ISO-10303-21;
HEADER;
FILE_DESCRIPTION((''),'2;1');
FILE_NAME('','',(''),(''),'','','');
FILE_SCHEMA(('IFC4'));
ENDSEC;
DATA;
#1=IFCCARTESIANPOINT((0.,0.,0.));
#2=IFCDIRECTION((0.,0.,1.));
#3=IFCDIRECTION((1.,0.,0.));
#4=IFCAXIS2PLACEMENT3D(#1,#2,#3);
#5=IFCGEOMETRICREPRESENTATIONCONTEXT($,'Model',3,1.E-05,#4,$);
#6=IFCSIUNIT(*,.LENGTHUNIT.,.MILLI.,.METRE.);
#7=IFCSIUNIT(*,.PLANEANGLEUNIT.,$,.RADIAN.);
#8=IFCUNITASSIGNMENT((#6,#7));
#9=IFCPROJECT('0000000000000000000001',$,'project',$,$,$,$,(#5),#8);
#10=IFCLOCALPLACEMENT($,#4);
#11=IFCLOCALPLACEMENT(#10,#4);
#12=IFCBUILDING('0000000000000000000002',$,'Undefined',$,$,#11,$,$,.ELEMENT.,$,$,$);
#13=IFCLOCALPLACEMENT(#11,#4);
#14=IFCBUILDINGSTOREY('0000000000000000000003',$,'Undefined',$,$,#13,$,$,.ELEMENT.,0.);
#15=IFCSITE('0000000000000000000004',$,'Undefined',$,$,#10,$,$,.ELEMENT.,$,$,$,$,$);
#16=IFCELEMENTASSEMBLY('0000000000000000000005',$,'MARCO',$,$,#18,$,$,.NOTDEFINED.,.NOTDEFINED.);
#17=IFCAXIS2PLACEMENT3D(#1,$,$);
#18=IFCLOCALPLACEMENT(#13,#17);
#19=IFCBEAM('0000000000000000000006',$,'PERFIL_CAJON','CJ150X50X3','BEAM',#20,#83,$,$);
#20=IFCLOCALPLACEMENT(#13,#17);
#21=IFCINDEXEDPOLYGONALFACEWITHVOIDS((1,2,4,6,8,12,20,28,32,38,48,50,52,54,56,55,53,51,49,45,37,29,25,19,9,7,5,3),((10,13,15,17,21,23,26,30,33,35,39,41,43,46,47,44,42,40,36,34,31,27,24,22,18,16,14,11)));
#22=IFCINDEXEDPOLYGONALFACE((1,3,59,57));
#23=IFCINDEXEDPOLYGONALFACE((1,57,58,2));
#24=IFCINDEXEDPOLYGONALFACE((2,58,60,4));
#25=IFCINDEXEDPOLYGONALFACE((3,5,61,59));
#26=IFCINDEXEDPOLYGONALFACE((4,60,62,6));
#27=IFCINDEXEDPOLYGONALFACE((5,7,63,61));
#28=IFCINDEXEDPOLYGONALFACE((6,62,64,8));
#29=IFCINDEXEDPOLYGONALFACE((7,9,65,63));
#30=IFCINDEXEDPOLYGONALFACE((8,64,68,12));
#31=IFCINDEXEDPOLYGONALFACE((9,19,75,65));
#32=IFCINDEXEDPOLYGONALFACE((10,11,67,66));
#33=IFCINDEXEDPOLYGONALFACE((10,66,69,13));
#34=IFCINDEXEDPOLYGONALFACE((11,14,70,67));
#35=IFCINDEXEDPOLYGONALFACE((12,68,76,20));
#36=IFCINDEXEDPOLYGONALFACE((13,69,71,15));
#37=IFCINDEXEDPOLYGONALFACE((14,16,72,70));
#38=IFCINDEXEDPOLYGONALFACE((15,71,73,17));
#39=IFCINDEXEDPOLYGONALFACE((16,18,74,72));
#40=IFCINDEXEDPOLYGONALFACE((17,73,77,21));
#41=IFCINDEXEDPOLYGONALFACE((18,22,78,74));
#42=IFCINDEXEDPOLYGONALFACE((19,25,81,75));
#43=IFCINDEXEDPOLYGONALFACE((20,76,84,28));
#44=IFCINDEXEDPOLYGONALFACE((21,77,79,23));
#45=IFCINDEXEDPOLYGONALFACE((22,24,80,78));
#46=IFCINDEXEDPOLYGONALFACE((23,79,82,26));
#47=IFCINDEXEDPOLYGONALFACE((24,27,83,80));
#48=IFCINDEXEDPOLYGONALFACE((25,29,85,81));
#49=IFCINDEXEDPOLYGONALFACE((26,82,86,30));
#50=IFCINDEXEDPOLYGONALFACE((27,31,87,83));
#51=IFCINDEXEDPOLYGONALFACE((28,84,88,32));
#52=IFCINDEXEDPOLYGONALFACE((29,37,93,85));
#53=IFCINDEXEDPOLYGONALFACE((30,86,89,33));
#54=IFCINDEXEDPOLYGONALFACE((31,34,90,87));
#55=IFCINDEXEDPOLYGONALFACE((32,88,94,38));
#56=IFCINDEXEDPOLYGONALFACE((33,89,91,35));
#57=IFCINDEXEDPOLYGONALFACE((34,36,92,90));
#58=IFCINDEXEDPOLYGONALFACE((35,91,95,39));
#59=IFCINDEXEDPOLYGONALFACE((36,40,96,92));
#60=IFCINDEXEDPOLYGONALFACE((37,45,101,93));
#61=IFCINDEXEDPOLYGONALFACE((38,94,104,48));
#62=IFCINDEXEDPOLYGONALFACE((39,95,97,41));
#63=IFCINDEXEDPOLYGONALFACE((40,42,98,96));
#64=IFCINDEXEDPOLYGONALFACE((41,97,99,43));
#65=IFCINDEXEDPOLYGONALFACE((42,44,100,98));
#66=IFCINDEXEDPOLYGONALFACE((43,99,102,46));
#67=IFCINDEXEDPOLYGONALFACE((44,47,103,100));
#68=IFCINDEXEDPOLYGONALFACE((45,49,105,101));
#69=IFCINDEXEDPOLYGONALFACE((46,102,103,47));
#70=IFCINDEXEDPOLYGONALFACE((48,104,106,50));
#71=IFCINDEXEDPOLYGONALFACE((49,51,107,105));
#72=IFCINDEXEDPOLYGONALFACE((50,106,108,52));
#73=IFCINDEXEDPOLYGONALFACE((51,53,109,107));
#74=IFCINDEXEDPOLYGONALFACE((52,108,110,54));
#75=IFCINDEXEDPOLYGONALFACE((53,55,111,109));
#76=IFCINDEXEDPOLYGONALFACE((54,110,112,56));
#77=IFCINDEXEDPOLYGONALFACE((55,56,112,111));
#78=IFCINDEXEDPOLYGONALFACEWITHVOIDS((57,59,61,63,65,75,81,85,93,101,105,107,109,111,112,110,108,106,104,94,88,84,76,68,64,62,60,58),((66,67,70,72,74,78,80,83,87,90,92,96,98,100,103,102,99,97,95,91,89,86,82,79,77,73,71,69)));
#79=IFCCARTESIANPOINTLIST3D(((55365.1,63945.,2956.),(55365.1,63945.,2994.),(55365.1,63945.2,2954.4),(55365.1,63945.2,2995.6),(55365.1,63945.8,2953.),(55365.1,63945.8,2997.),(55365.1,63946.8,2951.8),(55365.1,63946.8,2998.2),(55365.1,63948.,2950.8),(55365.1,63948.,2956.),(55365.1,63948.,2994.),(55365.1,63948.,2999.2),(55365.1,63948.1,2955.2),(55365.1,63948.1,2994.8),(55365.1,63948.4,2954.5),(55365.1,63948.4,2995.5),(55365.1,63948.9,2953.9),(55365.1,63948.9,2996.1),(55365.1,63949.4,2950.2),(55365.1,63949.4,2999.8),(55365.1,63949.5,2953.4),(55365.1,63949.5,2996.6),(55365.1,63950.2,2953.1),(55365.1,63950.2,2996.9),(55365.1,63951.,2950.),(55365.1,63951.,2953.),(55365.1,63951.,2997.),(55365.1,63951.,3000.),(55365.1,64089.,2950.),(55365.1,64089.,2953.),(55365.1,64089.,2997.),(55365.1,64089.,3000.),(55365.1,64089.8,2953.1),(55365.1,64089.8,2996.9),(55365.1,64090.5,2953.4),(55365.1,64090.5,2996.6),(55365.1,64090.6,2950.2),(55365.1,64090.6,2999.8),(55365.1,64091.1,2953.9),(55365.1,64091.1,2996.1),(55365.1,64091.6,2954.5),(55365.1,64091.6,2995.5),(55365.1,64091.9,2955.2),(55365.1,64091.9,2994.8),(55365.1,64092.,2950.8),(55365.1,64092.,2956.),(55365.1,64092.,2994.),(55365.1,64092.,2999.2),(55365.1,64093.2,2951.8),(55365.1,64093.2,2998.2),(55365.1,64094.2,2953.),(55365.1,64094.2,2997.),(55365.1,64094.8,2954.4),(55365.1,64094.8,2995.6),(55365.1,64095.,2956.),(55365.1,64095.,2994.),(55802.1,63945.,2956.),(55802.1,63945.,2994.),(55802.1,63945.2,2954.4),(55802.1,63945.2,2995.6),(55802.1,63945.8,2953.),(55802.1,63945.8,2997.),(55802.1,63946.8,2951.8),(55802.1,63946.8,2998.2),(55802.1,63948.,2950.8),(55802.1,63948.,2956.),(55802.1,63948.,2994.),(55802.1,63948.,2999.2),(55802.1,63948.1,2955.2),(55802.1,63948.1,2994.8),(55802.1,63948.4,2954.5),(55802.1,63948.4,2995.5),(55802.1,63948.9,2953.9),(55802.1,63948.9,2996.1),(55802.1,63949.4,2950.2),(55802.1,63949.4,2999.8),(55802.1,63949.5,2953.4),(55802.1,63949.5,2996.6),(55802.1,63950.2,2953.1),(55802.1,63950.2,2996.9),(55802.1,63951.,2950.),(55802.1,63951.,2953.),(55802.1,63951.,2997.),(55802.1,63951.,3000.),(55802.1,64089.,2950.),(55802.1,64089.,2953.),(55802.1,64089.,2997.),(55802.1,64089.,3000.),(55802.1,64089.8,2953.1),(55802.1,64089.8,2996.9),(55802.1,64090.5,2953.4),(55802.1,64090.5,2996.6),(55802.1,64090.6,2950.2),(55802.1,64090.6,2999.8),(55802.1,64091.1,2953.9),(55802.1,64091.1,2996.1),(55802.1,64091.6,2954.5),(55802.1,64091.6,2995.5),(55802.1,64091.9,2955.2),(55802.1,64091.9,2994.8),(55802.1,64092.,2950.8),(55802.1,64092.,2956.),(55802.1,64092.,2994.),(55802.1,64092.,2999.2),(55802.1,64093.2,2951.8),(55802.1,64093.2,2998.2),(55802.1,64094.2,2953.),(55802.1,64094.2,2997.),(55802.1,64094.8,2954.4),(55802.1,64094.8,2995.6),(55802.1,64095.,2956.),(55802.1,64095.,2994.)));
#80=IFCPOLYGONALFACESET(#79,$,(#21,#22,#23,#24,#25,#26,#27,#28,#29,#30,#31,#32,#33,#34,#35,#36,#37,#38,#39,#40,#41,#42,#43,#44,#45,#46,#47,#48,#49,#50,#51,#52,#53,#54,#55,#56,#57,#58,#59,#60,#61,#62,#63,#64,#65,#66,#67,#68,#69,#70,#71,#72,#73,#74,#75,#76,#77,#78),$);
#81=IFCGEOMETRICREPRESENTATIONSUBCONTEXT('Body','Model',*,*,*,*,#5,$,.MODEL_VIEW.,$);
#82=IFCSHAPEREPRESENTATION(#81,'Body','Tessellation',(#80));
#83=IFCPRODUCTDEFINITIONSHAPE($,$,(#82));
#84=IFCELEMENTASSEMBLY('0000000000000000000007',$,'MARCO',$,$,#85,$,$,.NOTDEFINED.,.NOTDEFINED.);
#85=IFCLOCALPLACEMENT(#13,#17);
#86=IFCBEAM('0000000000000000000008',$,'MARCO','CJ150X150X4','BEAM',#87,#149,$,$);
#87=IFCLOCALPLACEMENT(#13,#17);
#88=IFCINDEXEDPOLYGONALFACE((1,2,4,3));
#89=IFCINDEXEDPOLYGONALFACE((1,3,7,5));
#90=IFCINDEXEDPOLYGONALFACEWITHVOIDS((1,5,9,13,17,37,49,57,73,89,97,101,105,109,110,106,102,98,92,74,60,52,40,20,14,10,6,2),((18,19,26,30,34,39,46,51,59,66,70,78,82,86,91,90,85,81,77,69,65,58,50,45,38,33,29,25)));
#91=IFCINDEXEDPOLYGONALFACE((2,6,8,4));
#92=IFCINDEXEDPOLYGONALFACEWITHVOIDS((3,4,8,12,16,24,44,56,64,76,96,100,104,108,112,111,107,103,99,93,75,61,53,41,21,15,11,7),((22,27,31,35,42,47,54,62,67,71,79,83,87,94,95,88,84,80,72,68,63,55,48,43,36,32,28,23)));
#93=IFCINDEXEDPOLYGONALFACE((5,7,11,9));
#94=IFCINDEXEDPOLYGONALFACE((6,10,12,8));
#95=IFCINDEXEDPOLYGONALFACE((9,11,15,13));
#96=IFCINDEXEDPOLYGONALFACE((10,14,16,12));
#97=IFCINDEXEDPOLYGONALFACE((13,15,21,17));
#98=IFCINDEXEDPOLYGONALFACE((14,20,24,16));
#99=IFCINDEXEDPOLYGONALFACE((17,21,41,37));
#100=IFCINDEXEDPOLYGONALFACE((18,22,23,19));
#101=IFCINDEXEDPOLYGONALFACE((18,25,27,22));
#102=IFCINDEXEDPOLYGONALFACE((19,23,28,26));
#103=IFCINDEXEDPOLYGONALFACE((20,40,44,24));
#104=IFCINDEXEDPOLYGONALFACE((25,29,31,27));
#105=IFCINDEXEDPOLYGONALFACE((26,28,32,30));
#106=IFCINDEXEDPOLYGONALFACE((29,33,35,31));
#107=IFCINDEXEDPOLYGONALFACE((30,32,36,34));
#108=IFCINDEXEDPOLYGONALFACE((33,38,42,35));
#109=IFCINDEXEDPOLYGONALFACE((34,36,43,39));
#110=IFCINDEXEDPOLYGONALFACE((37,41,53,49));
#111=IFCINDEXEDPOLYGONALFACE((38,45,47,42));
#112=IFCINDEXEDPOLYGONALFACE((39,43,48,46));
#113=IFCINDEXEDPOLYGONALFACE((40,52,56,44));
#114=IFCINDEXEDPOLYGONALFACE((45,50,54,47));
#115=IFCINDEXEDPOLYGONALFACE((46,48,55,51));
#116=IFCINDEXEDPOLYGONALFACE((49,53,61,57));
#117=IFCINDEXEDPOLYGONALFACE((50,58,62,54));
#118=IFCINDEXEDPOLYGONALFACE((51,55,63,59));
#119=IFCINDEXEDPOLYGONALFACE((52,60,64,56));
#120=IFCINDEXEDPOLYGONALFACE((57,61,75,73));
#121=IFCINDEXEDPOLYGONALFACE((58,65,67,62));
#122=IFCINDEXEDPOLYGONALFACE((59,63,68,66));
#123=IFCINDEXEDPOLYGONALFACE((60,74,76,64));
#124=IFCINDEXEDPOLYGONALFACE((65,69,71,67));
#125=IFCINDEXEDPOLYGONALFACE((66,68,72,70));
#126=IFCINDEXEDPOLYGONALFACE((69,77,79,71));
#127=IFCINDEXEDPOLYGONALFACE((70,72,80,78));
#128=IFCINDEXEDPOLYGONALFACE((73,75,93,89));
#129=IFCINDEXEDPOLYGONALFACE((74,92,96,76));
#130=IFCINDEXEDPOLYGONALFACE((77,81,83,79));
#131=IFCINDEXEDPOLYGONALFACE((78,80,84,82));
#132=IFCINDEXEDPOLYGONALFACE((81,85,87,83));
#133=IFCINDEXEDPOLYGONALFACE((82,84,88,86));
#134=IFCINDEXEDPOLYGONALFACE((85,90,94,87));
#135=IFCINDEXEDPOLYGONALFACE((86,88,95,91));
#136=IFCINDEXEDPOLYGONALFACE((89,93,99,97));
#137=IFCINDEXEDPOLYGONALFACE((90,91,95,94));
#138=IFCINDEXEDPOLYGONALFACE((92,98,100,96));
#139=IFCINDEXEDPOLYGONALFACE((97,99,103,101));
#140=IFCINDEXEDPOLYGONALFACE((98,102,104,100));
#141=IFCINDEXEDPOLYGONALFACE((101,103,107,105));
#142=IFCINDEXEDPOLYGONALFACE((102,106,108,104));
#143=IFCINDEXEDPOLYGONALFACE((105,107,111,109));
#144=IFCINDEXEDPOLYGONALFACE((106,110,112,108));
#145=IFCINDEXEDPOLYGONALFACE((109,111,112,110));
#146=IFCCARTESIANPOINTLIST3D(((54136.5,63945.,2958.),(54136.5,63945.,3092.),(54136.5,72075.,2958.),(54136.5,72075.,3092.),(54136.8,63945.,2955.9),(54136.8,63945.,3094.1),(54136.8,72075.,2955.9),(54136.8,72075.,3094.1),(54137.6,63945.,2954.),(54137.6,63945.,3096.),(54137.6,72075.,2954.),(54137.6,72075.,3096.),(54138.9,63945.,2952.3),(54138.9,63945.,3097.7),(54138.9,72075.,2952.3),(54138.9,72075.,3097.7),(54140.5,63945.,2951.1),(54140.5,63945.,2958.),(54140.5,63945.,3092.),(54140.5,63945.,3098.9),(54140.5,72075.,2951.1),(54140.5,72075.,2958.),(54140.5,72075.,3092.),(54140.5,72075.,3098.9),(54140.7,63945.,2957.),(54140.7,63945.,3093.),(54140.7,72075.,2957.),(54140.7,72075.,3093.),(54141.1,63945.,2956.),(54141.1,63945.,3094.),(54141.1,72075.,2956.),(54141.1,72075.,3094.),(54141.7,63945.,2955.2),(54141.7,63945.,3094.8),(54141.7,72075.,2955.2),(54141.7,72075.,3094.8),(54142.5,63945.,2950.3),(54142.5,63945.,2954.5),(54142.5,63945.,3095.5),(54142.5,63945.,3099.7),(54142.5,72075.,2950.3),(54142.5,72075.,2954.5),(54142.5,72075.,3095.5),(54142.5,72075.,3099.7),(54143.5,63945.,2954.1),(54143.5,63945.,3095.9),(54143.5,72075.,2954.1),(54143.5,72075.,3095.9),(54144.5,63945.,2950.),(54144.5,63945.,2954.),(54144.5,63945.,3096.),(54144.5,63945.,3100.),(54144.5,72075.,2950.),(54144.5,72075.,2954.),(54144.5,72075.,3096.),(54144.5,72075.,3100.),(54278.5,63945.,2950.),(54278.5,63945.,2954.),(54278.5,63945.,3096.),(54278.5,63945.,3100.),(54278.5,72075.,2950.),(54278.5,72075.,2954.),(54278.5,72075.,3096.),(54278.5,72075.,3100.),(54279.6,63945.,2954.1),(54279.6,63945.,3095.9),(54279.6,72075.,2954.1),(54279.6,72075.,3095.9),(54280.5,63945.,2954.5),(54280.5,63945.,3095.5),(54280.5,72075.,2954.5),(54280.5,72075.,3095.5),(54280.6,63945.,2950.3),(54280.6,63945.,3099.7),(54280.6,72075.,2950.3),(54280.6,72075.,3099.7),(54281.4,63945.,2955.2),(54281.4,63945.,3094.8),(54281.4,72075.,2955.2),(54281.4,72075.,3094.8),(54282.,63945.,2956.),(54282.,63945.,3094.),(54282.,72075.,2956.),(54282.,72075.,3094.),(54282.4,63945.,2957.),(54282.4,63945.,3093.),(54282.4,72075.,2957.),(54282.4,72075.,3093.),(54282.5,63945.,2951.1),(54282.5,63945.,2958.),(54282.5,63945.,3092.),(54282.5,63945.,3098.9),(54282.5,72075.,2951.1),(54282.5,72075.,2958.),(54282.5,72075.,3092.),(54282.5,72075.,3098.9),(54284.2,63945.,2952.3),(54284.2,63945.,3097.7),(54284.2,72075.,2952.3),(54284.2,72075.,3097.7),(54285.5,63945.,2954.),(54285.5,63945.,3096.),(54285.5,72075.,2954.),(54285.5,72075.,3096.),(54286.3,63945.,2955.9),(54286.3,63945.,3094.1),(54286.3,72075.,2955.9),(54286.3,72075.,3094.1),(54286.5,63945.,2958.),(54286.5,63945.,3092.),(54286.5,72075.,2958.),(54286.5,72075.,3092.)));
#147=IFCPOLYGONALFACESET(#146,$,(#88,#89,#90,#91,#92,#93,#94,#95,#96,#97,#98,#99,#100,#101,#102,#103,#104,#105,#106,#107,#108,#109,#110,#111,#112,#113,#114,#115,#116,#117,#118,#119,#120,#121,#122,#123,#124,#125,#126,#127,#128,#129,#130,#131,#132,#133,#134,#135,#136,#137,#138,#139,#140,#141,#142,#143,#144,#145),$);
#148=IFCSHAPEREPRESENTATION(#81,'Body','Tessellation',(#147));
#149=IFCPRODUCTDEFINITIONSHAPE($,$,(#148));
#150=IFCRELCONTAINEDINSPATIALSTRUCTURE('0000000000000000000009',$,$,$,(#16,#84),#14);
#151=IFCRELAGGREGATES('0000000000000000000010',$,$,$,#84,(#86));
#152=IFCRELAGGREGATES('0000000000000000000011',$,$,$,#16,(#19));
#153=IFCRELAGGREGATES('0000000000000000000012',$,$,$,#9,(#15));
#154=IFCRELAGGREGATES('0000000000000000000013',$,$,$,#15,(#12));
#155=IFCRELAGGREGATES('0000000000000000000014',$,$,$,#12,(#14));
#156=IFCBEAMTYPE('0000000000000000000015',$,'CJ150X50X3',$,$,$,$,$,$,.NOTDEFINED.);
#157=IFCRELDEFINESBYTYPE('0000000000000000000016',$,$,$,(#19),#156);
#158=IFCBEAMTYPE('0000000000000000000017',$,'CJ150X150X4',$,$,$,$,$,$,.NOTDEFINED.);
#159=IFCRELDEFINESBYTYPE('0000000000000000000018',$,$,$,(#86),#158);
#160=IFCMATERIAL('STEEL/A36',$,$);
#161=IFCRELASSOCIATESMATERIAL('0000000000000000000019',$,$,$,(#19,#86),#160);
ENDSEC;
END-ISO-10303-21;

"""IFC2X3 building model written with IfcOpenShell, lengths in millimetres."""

from ifc_helpers import new_model, si_unit, frame, origin_with_axes, origin_2d_with_axis, place, context, subcontext, project, spatial, hollow_rectangle, extrude, material, type_object, element, aggregate, save


model = new_model("IFC2X3")

# Units and contexts
model_context = context("Model", 3, precision=1e-05, world=origin_with_axes())
body_context = subcontext(model_context, "Body", "Model", "MODEL_VIEW")
ifc_project = project(units=[si_unit("LENGTHUNIT", "METRE", prefix="MILLI"), si_unit("PLANEANGLEUNIT", "RADIAN")], contexts=[model_context])

# Site, building, storey
site_placement = place(None, origin_with_axes())
site = spatial("IfcSite", under=ifc_project, at=site_placement, Name="Undefined", CompositionType="ELEMENT")
building_placement = place(site_placement, origin_with_axes())
building = spatial("IfcBuilding", under=site, at=building_placement, Name="Undefined", CompositionType="ELEMENT")
storey_placement = place(building_placement, origin_with_axes())
storey = spatial("IfcBuildingStorey", under=building, at=storey_placement, Name="Undefined", CompositionType="ELEMENT", Elevation=0.0)

# Element assemblies, beams
assembly_1_placement = place(storey_placement, origin_with_axes())
assembly_1 = element("IfcElementAssembly", 1, at=assembly_1_placement, inside=storey, Name="MARCO", AssemblyPlace="NOTDEFINED", PredefinedType="NOTDEFINED")
ifc_material_1 = material(Name="STEEL/A36")
beam_type_1 = type_object("IfcBeamType", Name="CJ150X50X3", PredefinedType="NOTDEFINED")
beam_1_placement = place(assembly_1_placement, frame((55365.1, 64020.0, 2975.0), z_axis=(0.0, 1.0, 0.0), x_axis=(1.0, 0.0, 0.0)))
beam_1 = element("IfcBeam", 2, at=beam_1_placement, type_object=beam_type_1, material=ifc_material_1, Name="PERFIL_CAJON", Description="CJ150X50X3", ObjectType="BEAM", context=body_context, shape_type="SweptSolid", body=[
    extrude(hollow_rectangle(XDim=50.0, YDim=150.0, WallThickness=3.0, InnerFilletRadius=3.0, OuterFilletRadius=6.0, at=origin_2d_with_axis()), frame((437.0, 0.0, 0.0), z_axis=(-1.0, 0.0, 0.0), x_axis=(0.0, -1.0, 0.0)), (0.0, 0.0, 1.0), 437.0),
])
assembly_2_placement = place(storey_placement, origin_with_axes())
assembly_2 = element("IfcElementAssembly", 3, at=assembly_2_placement, inside=storey, Name="MARCO", AssemblyPlace="NOTDEFINED", PredefinedType="NOTDEFINED")
beam_type_2 = type_object("IfcBeamType", Name="CJ150X150X4", PredefinedType="NOTDEFINED")
beam_2_placement = place(assembly_2_placement, frame((54211.5, 63945.0, 3025.0), z_axis=(0.0, 0.0, 1.0), x_axis=(0.0, 1.0, 0.0)))
beam_2 = element("IfcBeam", 4, at=beam_2_placement, type_object=beam_type_2, material=ifc_material_1, Name="MARCO", Description="CJ150X150X4", ObjectType="BEAM", context=body_context, shape_type="SweptSolid", body=[
    extrude(hollow_rectangle(XDim=150.0, YDim=150.0, WallThickness=4.0, InnerFilletRadius=4.0, OuterFilletRadius=8.0, at=origin_2d_with_axis()), frame((8130.0, 0.0, 0.0), z_axis=(-1.0, 0.0, 0.0), x_axis=(0.0, -1.0, 0.0)), (0.0, 0.0, 1.0), 8130.0),
])

aggregate(assembly_2, [beam_2])
aggregate(assembly_1, [beam_1])

save(model, "model.ifc")
